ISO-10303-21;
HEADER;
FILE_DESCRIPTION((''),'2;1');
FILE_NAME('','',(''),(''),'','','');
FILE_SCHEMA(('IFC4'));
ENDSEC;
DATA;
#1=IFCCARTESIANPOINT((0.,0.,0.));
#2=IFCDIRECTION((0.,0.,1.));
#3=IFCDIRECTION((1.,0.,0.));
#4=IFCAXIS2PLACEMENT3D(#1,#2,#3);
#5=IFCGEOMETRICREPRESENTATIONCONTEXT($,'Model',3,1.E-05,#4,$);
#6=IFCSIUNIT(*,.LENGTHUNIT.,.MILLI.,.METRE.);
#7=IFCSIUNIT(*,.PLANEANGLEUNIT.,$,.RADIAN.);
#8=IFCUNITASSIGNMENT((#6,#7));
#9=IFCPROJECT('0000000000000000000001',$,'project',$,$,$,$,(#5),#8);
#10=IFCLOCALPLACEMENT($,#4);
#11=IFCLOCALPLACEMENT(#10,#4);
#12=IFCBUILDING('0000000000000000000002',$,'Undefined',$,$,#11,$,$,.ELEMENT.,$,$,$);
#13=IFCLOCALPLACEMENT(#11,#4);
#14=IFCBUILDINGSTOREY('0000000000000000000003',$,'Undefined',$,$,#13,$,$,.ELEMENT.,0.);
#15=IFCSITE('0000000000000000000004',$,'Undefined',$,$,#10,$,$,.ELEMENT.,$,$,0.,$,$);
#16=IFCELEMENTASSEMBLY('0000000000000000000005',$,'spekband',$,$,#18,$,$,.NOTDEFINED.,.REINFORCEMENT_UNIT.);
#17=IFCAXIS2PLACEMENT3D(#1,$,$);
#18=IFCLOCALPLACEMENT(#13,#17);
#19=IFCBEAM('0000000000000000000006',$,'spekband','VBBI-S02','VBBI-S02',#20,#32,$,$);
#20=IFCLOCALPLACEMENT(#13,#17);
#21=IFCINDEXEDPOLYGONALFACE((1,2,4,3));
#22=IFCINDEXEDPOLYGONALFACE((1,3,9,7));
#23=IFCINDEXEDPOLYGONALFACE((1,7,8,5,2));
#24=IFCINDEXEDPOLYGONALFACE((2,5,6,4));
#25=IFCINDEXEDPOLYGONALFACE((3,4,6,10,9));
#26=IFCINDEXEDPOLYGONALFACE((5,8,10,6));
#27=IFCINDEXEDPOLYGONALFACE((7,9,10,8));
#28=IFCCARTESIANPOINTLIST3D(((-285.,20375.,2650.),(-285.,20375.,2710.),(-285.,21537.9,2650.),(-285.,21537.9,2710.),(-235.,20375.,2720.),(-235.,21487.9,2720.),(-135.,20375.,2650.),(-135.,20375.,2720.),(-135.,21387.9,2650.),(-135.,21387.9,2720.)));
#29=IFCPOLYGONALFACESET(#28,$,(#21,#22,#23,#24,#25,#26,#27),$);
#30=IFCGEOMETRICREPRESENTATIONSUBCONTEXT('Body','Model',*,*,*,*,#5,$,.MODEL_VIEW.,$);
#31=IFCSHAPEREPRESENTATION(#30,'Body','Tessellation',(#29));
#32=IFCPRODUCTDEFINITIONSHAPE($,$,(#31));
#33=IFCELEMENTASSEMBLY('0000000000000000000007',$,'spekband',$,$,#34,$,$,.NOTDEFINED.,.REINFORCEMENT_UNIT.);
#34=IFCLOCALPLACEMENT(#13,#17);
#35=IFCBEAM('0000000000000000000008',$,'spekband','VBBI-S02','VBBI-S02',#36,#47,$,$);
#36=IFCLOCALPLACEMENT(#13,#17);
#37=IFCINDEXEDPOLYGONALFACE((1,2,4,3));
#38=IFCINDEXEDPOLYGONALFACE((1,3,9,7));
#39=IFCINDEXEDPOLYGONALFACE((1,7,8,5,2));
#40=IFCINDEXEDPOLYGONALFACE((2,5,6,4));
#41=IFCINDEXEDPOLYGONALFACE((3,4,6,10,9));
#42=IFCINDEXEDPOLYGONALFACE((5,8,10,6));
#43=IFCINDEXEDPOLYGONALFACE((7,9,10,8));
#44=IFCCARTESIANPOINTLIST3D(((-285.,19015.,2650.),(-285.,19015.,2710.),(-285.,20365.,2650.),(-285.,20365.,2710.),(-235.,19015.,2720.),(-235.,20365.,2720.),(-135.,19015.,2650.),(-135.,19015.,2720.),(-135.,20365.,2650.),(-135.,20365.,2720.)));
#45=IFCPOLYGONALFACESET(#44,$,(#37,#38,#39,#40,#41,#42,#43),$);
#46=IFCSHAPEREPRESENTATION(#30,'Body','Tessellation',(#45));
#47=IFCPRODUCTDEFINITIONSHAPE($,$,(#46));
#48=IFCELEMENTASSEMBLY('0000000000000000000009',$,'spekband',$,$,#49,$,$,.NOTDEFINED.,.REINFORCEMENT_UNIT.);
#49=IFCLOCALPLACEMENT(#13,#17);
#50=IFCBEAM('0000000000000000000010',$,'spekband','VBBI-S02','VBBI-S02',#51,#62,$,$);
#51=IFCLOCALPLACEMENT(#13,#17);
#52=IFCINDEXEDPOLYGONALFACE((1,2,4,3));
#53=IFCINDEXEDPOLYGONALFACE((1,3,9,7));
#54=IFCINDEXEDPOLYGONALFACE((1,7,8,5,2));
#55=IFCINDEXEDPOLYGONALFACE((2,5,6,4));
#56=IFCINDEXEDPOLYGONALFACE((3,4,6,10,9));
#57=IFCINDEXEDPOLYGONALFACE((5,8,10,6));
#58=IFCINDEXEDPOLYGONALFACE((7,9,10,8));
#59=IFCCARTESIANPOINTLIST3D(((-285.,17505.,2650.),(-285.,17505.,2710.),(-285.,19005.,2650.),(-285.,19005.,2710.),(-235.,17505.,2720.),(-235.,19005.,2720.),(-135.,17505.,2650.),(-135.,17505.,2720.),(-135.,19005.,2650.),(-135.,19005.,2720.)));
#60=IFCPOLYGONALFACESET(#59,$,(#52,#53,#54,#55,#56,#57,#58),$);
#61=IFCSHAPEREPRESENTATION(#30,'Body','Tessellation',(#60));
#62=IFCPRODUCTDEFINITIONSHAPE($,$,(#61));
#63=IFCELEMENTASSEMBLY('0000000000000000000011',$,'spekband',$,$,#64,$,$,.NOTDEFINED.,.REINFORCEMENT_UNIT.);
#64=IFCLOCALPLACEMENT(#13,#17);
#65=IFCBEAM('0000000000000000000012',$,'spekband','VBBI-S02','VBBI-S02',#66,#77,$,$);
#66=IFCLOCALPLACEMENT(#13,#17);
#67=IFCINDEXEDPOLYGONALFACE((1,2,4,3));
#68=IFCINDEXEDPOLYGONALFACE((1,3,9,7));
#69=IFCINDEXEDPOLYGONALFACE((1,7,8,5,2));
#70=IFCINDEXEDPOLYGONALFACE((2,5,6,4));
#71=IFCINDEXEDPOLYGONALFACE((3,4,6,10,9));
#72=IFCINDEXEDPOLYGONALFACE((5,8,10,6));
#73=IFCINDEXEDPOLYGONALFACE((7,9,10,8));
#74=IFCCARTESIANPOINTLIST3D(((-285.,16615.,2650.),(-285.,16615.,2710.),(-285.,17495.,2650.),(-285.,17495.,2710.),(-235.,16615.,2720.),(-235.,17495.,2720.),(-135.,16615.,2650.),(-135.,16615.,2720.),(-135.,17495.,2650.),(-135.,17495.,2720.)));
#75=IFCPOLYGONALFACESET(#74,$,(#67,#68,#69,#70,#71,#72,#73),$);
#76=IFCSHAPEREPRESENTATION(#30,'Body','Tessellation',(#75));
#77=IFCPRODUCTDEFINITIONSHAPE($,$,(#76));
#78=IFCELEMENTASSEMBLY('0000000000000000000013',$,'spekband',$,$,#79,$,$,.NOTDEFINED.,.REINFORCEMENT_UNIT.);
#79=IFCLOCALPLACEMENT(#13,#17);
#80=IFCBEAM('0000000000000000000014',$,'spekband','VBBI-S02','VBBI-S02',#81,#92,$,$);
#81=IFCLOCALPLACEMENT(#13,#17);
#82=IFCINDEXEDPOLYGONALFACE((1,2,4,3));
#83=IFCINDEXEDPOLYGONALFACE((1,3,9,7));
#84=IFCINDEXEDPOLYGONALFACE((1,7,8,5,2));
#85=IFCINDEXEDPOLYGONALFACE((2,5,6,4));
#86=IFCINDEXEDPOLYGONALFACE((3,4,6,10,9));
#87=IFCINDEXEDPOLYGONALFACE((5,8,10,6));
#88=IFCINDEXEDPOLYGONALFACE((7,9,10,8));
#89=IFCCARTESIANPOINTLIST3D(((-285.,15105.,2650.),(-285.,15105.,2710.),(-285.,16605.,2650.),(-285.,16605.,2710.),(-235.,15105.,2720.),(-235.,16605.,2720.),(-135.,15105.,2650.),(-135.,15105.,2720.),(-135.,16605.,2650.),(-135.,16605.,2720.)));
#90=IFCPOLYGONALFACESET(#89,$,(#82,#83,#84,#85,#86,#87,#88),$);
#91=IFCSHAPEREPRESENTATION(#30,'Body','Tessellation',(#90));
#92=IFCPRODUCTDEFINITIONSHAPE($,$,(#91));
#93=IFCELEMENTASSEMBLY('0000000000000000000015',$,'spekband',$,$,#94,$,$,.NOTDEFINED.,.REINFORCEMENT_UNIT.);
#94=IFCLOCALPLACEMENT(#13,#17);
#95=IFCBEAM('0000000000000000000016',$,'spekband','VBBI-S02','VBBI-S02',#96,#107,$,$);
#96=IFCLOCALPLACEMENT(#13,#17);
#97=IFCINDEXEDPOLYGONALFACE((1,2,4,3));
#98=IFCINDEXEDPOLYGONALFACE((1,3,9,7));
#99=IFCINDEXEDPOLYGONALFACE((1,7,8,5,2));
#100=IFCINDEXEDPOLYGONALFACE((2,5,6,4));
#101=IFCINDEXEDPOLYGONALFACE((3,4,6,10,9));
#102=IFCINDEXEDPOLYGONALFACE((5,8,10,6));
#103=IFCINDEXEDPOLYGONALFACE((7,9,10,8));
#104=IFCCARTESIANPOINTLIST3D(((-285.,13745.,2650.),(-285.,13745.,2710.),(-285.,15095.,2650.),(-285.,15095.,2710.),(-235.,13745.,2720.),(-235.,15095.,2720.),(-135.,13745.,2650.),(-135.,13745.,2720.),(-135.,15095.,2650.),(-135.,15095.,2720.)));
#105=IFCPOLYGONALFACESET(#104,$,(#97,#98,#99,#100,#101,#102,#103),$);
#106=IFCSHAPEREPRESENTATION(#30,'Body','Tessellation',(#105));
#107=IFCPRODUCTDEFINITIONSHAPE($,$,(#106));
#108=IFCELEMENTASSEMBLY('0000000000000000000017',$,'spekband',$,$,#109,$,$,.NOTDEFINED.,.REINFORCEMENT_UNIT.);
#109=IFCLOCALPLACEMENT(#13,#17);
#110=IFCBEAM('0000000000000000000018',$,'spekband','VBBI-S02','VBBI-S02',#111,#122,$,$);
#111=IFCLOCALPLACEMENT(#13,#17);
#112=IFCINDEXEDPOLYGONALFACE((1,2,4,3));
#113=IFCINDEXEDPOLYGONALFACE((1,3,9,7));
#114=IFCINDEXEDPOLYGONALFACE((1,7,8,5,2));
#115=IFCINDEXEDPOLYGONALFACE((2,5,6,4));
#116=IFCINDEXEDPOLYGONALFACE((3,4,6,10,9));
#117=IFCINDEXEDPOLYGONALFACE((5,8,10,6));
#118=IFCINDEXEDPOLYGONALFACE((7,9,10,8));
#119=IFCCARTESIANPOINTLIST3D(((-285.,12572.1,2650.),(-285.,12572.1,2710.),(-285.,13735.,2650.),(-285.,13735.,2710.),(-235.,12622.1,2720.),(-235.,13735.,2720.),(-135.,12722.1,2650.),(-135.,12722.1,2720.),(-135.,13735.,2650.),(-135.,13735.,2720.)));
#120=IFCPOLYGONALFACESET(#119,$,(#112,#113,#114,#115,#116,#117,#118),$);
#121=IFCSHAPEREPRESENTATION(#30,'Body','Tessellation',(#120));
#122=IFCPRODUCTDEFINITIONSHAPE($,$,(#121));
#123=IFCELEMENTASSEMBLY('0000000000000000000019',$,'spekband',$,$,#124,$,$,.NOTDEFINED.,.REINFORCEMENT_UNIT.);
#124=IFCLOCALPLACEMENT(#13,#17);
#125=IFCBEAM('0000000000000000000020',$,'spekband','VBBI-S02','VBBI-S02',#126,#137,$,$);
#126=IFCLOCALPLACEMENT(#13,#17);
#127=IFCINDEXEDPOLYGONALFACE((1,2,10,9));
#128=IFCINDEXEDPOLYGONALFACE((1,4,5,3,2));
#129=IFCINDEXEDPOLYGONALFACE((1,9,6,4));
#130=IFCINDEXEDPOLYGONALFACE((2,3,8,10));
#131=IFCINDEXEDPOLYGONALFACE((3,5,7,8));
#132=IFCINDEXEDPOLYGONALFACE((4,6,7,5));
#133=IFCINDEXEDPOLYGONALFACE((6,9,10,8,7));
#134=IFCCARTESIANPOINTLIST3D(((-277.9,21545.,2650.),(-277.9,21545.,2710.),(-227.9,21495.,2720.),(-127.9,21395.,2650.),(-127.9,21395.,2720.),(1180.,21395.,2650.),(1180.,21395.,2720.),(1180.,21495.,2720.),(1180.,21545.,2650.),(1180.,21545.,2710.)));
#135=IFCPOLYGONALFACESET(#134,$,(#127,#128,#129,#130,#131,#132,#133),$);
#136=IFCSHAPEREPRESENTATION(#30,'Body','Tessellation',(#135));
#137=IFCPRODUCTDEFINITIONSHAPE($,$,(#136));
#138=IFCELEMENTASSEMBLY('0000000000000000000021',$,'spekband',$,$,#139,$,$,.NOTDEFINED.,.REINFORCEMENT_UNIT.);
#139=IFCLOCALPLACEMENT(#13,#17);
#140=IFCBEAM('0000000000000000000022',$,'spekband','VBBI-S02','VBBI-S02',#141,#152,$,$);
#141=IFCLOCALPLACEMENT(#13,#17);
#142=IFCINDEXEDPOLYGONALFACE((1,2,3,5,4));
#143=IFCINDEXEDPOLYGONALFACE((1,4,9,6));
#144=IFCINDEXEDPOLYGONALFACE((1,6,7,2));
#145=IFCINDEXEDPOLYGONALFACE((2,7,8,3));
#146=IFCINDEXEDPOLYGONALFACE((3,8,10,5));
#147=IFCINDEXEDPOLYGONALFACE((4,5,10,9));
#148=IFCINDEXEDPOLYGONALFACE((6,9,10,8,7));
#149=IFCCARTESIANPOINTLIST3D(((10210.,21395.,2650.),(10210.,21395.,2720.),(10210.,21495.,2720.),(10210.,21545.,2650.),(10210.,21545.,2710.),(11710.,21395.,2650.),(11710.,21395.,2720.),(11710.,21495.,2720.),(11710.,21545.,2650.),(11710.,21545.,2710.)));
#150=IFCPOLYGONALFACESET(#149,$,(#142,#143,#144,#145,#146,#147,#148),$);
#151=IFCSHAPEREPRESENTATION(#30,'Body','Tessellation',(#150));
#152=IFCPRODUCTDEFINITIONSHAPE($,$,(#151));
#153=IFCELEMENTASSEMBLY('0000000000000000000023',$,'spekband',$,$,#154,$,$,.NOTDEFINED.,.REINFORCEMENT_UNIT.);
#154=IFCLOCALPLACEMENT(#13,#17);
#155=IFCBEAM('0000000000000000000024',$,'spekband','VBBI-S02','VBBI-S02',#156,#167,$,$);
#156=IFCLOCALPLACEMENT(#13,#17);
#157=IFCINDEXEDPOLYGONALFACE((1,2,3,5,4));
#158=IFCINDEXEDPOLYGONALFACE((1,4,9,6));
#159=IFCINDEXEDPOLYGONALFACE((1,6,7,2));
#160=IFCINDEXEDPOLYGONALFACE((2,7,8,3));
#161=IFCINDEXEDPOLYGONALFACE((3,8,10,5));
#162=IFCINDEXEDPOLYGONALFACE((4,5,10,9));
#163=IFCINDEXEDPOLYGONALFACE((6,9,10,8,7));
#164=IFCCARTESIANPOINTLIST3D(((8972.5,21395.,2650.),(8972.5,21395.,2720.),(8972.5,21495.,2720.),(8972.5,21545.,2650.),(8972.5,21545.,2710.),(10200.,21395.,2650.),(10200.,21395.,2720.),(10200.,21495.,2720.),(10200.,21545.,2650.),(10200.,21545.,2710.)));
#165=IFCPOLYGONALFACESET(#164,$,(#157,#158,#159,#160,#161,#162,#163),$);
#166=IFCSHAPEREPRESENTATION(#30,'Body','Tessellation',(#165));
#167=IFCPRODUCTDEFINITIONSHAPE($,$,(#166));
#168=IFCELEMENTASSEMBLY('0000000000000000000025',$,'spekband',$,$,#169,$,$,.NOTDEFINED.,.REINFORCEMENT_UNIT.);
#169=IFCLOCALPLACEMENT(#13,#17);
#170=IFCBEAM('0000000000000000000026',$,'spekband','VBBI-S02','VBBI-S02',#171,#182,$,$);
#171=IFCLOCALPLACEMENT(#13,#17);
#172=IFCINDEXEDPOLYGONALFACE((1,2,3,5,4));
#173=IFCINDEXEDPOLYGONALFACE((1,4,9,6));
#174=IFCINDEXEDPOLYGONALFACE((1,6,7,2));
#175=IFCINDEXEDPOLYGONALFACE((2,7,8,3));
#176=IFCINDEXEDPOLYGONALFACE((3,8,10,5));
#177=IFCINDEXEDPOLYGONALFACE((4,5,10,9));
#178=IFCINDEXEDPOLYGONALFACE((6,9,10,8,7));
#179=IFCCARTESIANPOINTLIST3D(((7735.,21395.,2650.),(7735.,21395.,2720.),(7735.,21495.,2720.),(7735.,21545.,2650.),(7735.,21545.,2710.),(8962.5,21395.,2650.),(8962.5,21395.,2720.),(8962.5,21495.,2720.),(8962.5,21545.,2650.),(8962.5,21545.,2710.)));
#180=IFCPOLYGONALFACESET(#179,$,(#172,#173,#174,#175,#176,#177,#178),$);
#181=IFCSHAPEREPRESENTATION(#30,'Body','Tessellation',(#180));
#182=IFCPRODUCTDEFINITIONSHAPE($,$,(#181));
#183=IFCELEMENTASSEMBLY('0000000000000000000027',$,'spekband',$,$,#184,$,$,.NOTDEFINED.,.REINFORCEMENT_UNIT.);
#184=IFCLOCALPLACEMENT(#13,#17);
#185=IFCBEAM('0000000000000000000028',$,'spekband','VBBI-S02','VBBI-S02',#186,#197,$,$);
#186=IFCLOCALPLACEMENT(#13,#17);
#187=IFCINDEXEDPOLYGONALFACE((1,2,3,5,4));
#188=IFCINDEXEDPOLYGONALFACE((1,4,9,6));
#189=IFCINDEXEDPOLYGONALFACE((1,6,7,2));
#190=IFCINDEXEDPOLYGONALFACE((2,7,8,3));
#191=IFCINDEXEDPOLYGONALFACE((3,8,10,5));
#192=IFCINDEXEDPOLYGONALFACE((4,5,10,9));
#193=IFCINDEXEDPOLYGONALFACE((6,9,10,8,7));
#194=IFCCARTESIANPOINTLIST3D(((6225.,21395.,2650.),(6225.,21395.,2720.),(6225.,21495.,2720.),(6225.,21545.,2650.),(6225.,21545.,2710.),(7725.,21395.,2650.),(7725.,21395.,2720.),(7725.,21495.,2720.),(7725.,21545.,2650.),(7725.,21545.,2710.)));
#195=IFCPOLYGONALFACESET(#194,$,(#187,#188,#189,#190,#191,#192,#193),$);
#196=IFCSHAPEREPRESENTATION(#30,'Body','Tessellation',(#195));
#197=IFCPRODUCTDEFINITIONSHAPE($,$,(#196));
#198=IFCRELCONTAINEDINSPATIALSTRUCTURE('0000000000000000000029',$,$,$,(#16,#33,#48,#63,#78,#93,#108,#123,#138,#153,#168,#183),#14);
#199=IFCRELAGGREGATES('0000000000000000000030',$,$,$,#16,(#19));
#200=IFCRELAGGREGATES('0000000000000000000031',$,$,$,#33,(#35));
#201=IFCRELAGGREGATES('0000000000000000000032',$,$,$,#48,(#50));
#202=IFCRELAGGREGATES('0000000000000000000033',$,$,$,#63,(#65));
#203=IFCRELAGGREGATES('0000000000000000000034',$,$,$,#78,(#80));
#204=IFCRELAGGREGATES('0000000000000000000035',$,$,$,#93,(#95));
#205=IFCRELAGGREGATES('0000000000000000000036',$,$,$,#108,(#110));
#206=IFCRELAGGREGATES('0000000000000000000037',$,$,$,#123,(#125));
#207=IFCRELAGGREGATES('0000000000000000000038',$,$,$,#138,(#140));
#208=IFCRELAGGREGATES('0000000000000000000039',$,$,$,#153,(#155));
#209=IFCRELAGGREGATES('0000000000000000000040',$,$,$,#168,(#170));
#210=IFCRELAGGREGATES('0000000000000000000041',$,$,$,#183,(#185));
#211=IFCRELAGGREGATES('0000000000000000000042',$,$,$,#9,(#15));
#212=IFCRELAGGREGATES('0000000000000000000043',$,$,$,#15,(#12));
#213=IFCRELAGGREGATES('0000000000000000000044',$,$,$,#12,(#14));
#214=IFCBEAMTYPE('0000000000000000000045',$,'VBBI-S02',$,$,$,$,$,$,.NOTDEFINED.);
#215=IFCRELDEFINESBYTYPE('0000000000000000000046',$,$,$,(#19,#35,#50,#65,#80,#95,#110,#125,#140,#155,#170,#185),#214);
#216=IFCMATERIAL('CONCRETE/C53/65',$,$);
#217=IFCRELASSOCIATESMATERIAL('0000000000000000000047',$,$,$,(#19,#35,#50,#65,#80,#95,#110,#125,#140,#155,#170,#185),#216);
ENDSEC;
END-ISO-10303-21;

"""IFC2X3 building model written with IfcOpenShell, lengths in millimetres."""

from ifc_helpers import new_model, si_unit, frame, origin_with_axes, place, context, subcontext, project, spatial, polyline, outline, extrude, clip, halfspace, material, type_object, element, aggregate, save


model = new_model("IFC2X3")

# Units and contexts
model_context = context("Model", 3, precision=1e-05, world=origin_with_axes())
body_context = subcontext(model_context, "Body", "Model", "MODEL_VIEW")
ifc_project = project(units=[si_unit("LENGTHUNIT", "METRE", prefix="MILLI"), si_unit("PLANEANGLEUNIT", "RADIAN")], contexts=[model_context])

# Site, building, storey
site_placement = place(None, origin_with_axes())
site = spatial("IfcSite", under=ifc_project, at=site_placement, Name="Undefined", CompositionType="ELEMENT", RefElevation=0.0)
building_placement = place(site_placement, origin_with_axes())
building = spatial("IfcBuilding", under=site, at=building_placement, Name="Undefined", CompositionType="ELEMENT")
storey_placement = place(building_placement, origin_with_axes())
storey = spatial("IfcBuildingStorey", under=building, at=storey_placement, Name="Undefined", CompositionType="ELEMENT", Elevation=0.0)

# Element assemblies, beams
assembly_1_placement = place(storey_placement, origin_with_axes())
assembly_1 = element("IfcElementAssembly", 1, at=assembly_1_placement, inside=storey, Name="spekband", AssemblyPlace="NOTDEFINED", PredefinedType="REINFORCEMENT_UNIT")
ifc_material = material(Name="CONCRETE/C53/65")
beam_type_1 = type_object("IfcBeamType", Name="VBBI-S02", PredefinedType="NOTDEFINED")
beam_1_placement = place(assembly_1_placement, frame((-210.0, 21545.0, 2685.0), z_axis=(-1.0, 0.0, 0.0), x_axis=(0.0, -1.0, 0.0)))
beam_1 = element("IfcBeam", 2, at=beam_1_placement, type_object=beam_type_1, material=ifc_material, Name="spekband", Description="VBBI-S02", ObjectType="VBBI-S02", context=body_context, shape_type="Clipping", body=[
    clip(extrude(outline(polyline([(35.0, -75.0), (-35.0, -75.0), (-35.0, 25.0), (-25.0, 75.0), (35.0, 75.0), (35.0, -75.0)])), frame((1170.0, 0.0, 0.0), z_axis=(-1.0, 0.0, 0.0), x_axis=(0.0, -1.0, 0.0)), (0.0, 0.0, 1.0), 1163.7), halfspace(frame((3.5, 0.0, 78.5), z_axis=(0.707107, 0.0, 0.707107), x_axis=(0.0, 1.0, 0.0)), True)),
])
aggregate(assembly_1, [beam_1])
assembly_2_placement = place(storey_placement, origin_with_axes())
assembly_2 = element("IfcElementAssembly", 3, at=assembly_2_placement, inside=storey, Name="spekband", AssemblyPlace="NOTDEFINED", PredefinedType="REINFORCEMENT_UNIT")
beam_2_placement = place(assembly_2_placement, frame((-210.0, 20365.0, 2685.0), z_axis=(-1.0, 0.0, 0.0), x_axis=(0.0, -1.0, 0.0)))
beam_2 = element("IfcBeam", 4, at=beam_2_placement, type_object=beam_type_1, material=ifc_material, Name="spekband", Description="VBBI-S02", ObjectType="VBBI-S02", context=body_context, shape_type="SweptSolid", body=[
    extrude(outline(polyline([(35.0, -75.0), (-35.0, -75.0), (-35.0, 25.0), (-25.0, 75.0), (35.0, 75.0), (35.0, -75.0)])), frame((1350.0, 0.0, 0.0), z_axis=(-1.0, 0.0, 0.0), x_axis=(0.0, -1.0, 0.0)), (0.0, 0.0, 1.0), 1350.0),
])
aggregate(assembly_2, [beam_2])
assembly_3_placement = place(storey_placement, origin_with_axes())
assembly_3 = element("IfcElementAssembly", 5, at=assembly_3_placement, inside=storey, Name="spekband", AssemblyPlace="NOTDEFINED", PredefinedType="REINFORCEMENT_UNIT")
beam_3_placement = place(assembly_3_placement, frame((-210.0, 19005.0, 2685.0), z_axis=(-1.0, 0.0, 0.0), x_axis=(0.0, -1.0, 0.0)))
beam_3 = element("IfcBeam", 6, at=beam_3_placement, type_object=beam_type_1, material=ifc_material, Name="spekband", Description="VBBI-S02", ObjectType="VBBI-S02", context=body_context, shape_type="SweptSolid", body=[
    extrude(outline(polyline([(35.0, -75.0), (-35.0, -75.0), (-35.0, 25.0), (-25.0, 75.0), (35.0, 75.0), (35.0, -75.0)])), frame((1500.0, 0.0, 0.0), z_axis=(-1.0, 0.0, 0.0), x_axis=(0.0, -1.0, 0.0)), (0.0, 0.0, 1.0), 1500.0),
])
aggregate(assembly_3, [beam_3])
assembly_4_placement = place(storey_placement, origin_with_axes())
assembly_4 = element("IfcElementAssembly", 7, at=assembly_4_placement, inside=storey, Name="spekband", AssemblyPlace="NOTDEFINED", PredefinedType="REINFORCEMENT_UNIT")
beam_4_placement = place(assembly_4_placement, frame((-210.0, 17495.0, 2685.0), z_axis=(-1.0, 0.0, 0.0), x_axis=(0.0, -1.0, 0.0)))
beam_4 = element("IfcBeam", 8, at=beam_4_placement, type_object=beam_type_1, material=ifc_material, Name="spekband", Description="VBBI-S02", ObjectType="VBBI-S02", context=body_context, shape_type="SweptSolid", body=[
    extrude(outline(polyline([(35.0, -75.0), (-35.0, -75.0), (-35.0, 25.0), (-25.0, 75.0), (35.0, 75.0), (35.0, -75.0)])), frame((880.0, 0.0, 0.0), z_axis=(-1.0, 0.0, 0.0), x_axis=(0.0, -1.0, 0.0)), (0.0, 0.0, 1.0), 880.0),
])
aggregate(assembly_4, [beam_4])
assembly_5_placement = place(storey_placement, origin_with_axes())
assembly_5 = element("IfcElementAssembly", 9, at=assembly_5_placement, inside=storey, Name="spekband", AssemblyPlace="NOTDEFINED", PredefinedType="REINFORCEMENT_UNIT")
beam_5_placement = place(assembly_5_placement, frame((-210.0, 16605.0, 2685.0), z_axis=(-1.0, 0.0, 0.0), x_axis=(0.0, -1.0, 0.0)))
beam_5 = element("IfcBeam", 10, at=beam_5_placement, type_object=beam_type_1, material=ifc_material, Name="spekband", Description="VBBI-S02", ObjectType="VBBI-S02", context=body_context, shape_type="SweptSolid", body=[
    extrude(outline(polyline([(35.0, -75.0), (-35.0, -75.0), (-35.0, 25.0), (-25.0, 75.0), (35.0, 75.0), (35.0, -75.0)])), frame((1500.0, 0.0, 0.0), z_axis=(-1.0, 0.0, 0.0), x_axis=(0.0, -1.0, 0.0)), (0.0, 0.0, 1.0), 1500.0),
])
aggregate(assembly_5, [beam_5])
assembly_6_placement = place(storey_placement, origin_with_axes())
assembly_6 = element("IfcElementAssembly", 11, at=assembly_6_placement, inside=storey, Name="spekband", AssemblyPlace="NOTDEFINED", PredefinedType="REINFORCEMENT_UNIT")
beam_6_placement = place(assembly_6_placement, frame((-210.0, 15095.0, 2685.0), z_axis=(-1.0, 0.0, 0.0), x_axis=(0.0, -1.0, 0.0)))
beam_6 = element("IfcBeam", 12, at=beam_6_placement, type_object=beam_type_1, material=ifc_material, Name="spekband", Description="VBBI-S02", ObjectType="VBBI-S02", context=body_context, shape_type="SweptSolid", body=[
    extrude(outline(polyline([(35.0, -75.0), (-35.0, -75.0), (-35.0, 25.0), (-25.0, 75.0), (35.0, 75.0), (35.0, -75.0)])), frame((1350.0, 0.0, 0.0), z_axis=(-1.0, 0.0, 0.0), x_axis=(0.0, -1.0, 0.0)), (0.0, 0.0, 1.0), 1350.0),
])
aggregate(assembly_6, [beam_6])
assembly_7_placement = place(storey_placement, origin_with_axes())
assembly_7 = element("IfcElementAssembly", 13, at=assembly_7_placement, inside=storey, Name="spekband", AssemblyPlace="NOTDEFINED", PredefinedType="REINFORCEMENT_UNIT")
beam_7_placement = place(assembly_7_placement, frame((-210.0, 13735.0, 2685.0), z_axis=(-1.0, 0.0, 0.0), x_axis=(0.0, -1.0, 0.0)))
beam_7 = element("IfcBeam", 14, at=beam_7_placement, type_object=beam_type_1, material=ifc_material, Name="spekband", Description="VBBI-S02", ObjectType="VBBI-S02", context=body_context, shape_type="Clipping", body=[
    clip(extrude(outline(polyline([(35.0, -75.0), (-35.0, -75.0), (-35.0, 25.0), (-25.0, 75.0), (35.0, 75.0), (35.0, -75.0)])), frame((1163.7, 0.0, 0.0), z_axis=(-1.0, 0.0, 0.0), x_axis=(0.0, -1.0, 0.0)), (0.0, 0.0, 1.0), 1163.7), halfspace(frame((1166.5, 0.0, 78.5), z_axis=(0.707107, 0.0, -0.707107), x_axis=(0.0, 1.0, 0.0)), False)),
])
aggregate(assembly_7, [beam_7])
assembly_8_placement = place(storey_placement, origin_with_axes())
assembly_8 = element("IfcElementAssembly", 15, at=assembly_8_placement, inside=storey, Name="spekband", AssemblyPlace="NOTDEFINED", PredefinedType="REINFORCEMENT_UNIT")
beam_8_placement = place(assembly_8_placement, frame((1180.0, 21470.0, 2685.0), z_axis=(0.0, 1.0, 0.0), x_axis=(-1.0, 0.0, 0.0)))
beam_8 = element("IfcBeam", 16, at=beam_8_placement, type_object=beam_type_1, material=ifc_material, Name="spekband", Description="VBBI-S02", ObjectType="VBBI-S02", context=body_context, shape_type="Clipping", body=[
    clip(extrude(outline(polyline([(35.0, -75.0), (-35.0, -75.0), (-35.0, 25.0), (-25.0, 75.0), (35.0, 75.0), (35.0, -75.0)])), frame((1458.7, 0.0, 0.0), z_axis=(-1.0, 0.0, 0.0), x_axis=(0.0, -1.0, 0.0)), (0.0, 0.0, 1.0), 1458.7), halfspace(frame((1461.5, 0.0, 78.5), z_axis=(0.707107, 0.0, -0.707107), x_axis=(0.0, 1.0, 0.0)), False)),
])
aggregate(assembly_8, [beam_8])
assembly_9_placement = place(storey_placement, origin_with_axes())
assembly_9 = element("IfcElementAssembly", 17, at=assembly_9_placement, inside=storey, Name="spekband", AssemblyPlace="NOTDEFINED", PredefinedType="REINFORCEMENT_UNIT")
beam_9_placement = place(assembly_9_placement, frame((11710.0, 21470.0, 2685.0), z_axis=(0.0, 1.0, 0.0), x_axis=(-1.0, 0.0, 0.0)))
beam_9 = element("IfcBeam", 18, at=beam_9_placement, type_object=beam_type_1, material=ifc_material, Name="spekband", Description="VBBI-S02", ObjectType="VBBI-S02", context=body_context, shape_type="SweptSolid", body=[
    extrude(outline(polyline([(35.0, -75.0), (-35.0, -75.0), (-35.0, 25.0), (-25.0, 75.0), (35.0, 75.0), (35.0, -75.0)])), frame((1500.0, 0.0, 0.0), z_axis=(-1.0, 0.0, 0.0), x_axis=(0.0, -1.0, 0.0)), (0.0, 0.0, 1.0), 1500.0),
])
aggregate(assembly_9, [beam_9])
assembly_10_placement = place(storey_placement, origin_with_axes())
assembly_10 = element("IfcElementAssembly", 19, at=assembly_10_placement, inside=storey, Name="spekband", AssemblyPlace="NOTDEFINED", PredefinedType="REINFORCEMENT_UNIT")
beam_10_placement = place(assembly_10_placement, frame((10200.0, 21470.0, 2685.0), z_axis=(0.0, 1.0, 0.0), x_axis=(-1.0, 0.0, 0.0)))
beam_10 = element("IfcBeam", 20, at=beam_10_placement, type_object=beam_type_1, material=ifc_material, Name="spekband", Description="VBBI-S02", ObjectType="VBBI-S02", context=body_context, shape_type="SweptSolid", body=[
    extrude(outline(polyline([(35.0, -75.0), (-35.0, -75.0), (-35.0, 25.0), (-25.0, 75.0), (35.0, 75.0), (35.0, -75.0)])), frame((1227.5, 0.0, 0.0), z_axis=(-1.0, 0.0, 0.0), x_axis=(0.0, -1.0, 0.0)), (0.0, 0.0, 1.0), 1227.5),
])
aggregate(assembly_10, [beam_10])
assembly_11_placement = place(storey_placement, origin_with_axes())
assembly_11 = element("IfcElementAssembly", 21, at=assembly_11_placement, inside=storey, Name="spekband", AssemblyPlace="NOTDEFINED", PredefinedType="REINFORCEMENT_UNIT")
beam_11_placement = place(assembly_11_placement, frame((8962.5, 21470.0, 2685.0), z_axis=(0.0, 1.0, 0.0), x_axis=(-1.0, 0.0, 0.0)))
beam_11 = element("IfcBeam", 22, at=beam_11_placement, type_object=beam_type_1, material=ifc_material, Name="spekband", Description="VBBI-S02", ObjectType="VBBI-S02", context=body_context, shape_type="SweptSolid", body=[
    extrude(outline(polyline([(35.0, -75.0), (-35.0, -75.0), (-35.0, 25.0), (-25.0, 75.0), (35.0, 75.0), (35.0, -75.0)])), frame((1227.5, 0.0, 0.0), z_axis=(-1.0, 0.0, 0.0), x_axis=(0.0, -1.0, 0.0)), (0.0, 0.0, 1.0), 1227.5),
])
aggregate(assembly_11, [beam_11])
assembly_12_placement = place(storey_placement, origin_with_axes())
assembly_12 = element("IfcElementAssembly", 23, at=assembly_12_placement, inside=storey, Name="spekband", AssemblyPlace="NOTDEFINED", PredefinedType="REINFORCEMENT_UNIT")
beam_12_placement = place(assembly_12_placement, frame((7725.0, 21470.0, 2685.0), z_axis=(0.0, 1.0, 0.0), x_axis=(-1.0, 0.0, 0.0)))
beam_12 = element("IfcBeam", 24, at=beam_12_placement, type_object=beam_type_1, material=ifc_material, Name="spekband", Description="VBBI-S02", ObjectType="VBBI-S02", context=body_context, shape_type="SweptSolid", body=[
    extrude(outline(polyline([(35.0, -75.0), (-35.0, -75.0), (-35.0, 25.0), (-25.0, 75.0), (35.0, 75.0), (35.0, -75.0)])), frame((1500.0, 0.0, 0.0), z_axis=(-1.0, 0.0, 0.0), x_axis=(0.0, -1.0, 0.0)), (0.0, 0.0, 1.0), 1500.0),
])
aggregate(assembly_12, [beam_12])

save(model, "model.ifc")
